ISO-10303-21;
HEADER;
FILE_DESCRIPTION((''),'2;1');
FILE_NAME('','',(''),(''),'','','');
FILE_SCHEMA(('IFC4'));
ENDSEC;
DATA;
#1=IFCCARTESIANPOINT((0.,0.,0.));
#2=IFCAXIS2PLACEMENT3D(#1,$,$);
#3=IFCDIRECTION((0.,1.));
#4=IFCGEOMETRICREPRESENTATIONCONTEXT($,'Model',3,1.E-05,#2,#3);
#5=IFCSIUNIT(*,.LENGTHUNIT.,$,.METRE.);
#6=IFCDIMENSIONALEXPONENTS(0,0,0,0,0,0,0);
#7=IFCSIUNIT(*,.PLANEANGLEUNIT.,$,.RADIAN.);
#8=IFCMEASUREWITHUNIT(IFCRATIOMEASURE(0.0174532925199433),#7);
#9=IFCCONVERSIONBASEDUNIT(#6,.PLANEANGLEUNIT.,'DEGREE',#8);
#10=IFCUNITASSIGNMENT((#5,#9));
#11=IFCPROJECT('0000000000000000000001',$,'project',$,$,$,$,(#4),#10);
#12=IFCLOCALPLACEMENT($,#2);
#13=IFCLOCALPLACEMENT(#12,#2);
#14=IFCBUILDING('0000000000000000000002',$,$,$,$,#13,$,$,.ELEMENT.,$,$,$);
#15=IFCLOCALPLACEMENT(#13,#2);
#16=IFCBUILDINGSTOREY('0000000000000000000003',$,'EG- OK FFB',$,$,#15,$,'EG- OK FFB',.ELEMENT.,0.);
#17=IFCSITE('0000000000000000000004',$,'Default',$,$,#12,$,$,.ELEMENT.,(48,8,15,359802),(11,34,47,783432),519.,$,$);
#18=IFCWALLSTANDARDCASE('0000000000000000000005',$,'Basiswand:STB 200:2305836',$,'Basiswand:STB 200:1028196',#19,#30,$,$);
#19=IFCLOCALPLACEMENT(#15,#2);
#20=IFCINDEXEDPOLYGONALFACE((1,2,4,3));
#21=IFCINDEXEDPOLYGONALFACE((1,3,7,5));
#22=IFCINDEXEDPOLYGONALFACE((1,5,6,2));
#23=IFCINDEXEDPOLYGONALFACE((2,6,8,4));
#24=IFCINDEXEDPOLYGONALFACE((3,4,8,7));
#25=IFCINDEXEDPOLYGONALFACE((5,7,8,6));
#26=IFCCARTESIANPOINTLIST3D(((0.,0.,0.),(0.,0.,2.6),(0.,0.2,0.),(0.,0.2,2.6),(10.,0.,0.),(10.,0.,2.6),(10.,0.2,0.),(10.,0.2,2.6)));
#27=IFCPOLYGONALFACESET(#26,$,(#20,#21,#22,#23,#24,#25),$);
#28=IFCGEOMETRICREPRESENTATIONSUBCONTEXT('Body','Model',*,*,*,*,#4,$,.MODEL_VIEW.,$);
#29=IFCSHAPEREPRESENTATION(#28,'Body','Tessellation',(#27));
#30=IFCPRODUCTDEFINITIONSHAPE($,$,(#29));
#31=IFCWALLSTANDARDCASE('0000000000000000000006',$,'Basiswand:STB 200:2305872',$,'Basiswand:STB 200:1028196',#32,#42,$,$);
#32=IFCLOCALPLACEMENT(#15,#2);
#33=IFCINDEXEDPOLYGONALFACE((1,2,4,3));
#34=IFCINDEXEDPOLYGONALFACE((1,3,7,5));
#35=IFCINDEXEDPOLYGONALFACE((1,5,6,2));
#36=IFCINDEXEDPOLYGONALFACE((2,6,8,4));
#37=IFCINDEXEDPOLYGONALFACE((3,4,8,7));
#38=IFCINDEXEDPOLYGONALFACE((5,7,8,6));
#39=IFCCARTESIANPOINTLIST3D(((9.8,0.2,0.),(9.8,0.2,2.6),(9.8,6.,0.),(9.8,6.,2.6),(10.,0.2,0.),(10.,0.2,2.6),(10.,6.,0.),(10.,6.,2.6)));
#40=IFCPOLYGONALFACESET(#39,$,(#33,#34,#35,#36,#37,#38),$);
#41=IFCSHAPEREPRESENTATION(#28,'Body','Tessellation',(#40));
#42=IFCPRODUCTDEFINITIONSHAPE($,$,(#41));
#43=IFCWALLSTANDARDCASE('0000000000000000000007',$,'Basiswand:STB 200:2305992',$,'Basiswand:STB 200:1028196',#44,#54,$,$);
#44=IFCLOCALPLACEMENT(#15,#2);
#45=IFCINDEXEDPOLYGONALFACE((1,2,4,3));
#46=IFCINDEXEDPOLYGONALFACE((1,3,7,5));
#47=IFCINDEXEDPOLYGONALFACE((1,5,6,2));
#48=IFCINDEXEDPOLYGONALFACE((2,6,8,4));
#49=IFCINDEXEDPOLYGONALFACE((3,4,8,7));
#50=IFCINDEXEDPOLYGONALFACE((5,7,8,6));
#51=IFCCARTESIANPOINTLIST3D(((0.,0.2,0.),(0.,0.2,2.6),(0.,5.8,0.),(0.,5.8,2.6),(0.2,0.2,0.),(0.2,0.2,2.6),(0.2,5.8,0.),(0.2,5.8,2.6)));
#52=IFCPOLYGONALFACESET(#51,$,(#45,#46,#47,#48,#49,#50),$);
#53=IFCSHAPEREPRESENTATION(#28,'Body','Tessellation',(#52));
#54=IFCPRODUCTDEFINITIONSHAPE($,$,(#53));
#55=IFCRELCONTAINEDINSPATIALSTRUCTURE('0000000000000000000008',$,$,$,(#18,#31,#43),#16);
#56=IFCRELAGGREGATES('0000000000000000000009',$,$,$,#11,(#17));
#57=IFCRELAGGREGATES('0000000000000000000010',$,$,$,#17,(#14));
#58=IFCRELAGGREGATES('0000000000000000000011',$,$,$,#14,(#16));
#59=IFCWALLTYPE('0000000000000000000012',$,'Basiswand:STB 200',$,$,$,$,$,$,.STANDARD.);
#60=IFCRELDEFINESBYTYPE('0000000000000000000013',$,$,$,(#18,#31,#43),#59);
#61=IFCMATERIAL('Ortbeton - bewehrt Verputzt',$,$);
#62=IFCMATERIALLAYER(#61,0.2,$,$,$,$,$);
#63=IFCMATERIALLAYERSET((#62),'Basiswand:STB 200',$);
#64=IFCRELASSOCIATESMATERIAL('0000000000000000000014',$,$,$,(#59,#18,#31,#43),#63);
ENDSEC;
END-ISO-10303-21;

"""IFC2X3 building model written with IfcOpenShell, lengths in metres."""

from ifc_helpers import new_model, entity, si_unit, converted_unit, direction, frame, frame_2d, origin, place, context, subcontext, project, spatial, rectangle, extrude, material, layer, layer_set, layer_usage, type_object, element, save


model = new_model("IFC2X3")

# Units and contexts
model_context = context("Model", 3, precision=1e-05, world=origin(), true_north=direction((0.0, 1.0)))
body_context = subcontext(model_context, "Body", "Model", "MODEL_VIEW")
ifc_project = project(units=[si_unit("LENGTHUNIT", "METRE"), converted_unit("PLANEANGLEUNIT", "DEGREE", entity("IfcRatioMeasure", 0.0174532925199433), si_unit("PLANEANGLEUNIT", "RADIAN"), dimensions=[0, 0, 0, 0, 0, 0, 0])], contexts=[model_context])

# Site, building, storey
site_placement = place(None, frame((0.0, 0.0, 0.0)))
site = spatial("IfcSite", under=ifc_project, at=site_placement, Name="Default", CompositionType="ELEMENT", RefLatitude=(48, 8, 15, 359802), RefLongitude=(11, 34, 47, 783432), RefElevation=519.0)
building_placement = place(site_placement, origin())
building = spatial("IfcBuilding", under=site, at=building_placement, CompositionType="ELEMENT")
storey_placement = place(building_placement, origin())
storey = spatial("IfcBuildingStorey", under=building, at=storey_placement, Name="EG- OK FFB", LongName="EG- OK FFB", CompositionType="ELEMENT", Elevation=0.0)

# Walls
ifc_material = material(Name="Ortbeton - bewehrt Verputzt")
ifc_layer = layer(ifc_material, 0.2)
ifc_layer_set = layer_set([ifc_layer], Name="Basiswand:STB 200")
ifc_layer_usage_1 = layer_usage(ifc_layer_set, "AXIS2", "NEGATIVE", 0.1)
wall_type = type_object("IfcWallType", Name="Basiswand:STB 200", PredefinedType="STANDARD", material=ifc_layer_set)
wall_1_placement = place(storey_placement, frame((0.0, 0.1, 0.0)))
element("IfcWallStandardCase", 1, at=wall_1_placement, inside=storey, type_object=wall_type, material=ifc_layer_usage_1, Name="Basiswand:STB 200:2305836", ObjectType="Basiswand:STB 200:1028196", context=body_context, shape_type="SweptSolid", body=[
    extrude(rectangle(XDim=10.0, YDim=0.2, at=frame_2d((5.0, 0.0), x_axis=(-1.0, 0.0))), origin(), (0.0, 0.0, 1.0), 2.6),
])
ifc_layer_usage_2 = layer_usage(ifc_layer_set, "AXIS2", "NEGATIVE", 0.1)
wall_2_placement = place(storey_placement, frame((9.9, 0.2, 0.0), z_axis=(0.0, 0.0, 1.0), x_axis=(0.0, 1.0, 0.0)))
element("IfcWallStandardCase", 2, at=wall_2_placement, inside=storey, type_object=wall_type, material=ifc_layer_usage_2, Name="Basiswand:STB 200:2305872", ObjectType="Basiswand:STB 200:1028196", context=body_context, shape_type="SweptSolid", body=[
    extrude(rectangle(XDim=5.8, YDim=0.2, at=frame_2d((2.9, 0.0), x_axis=(-1.0, 0.0))), origin(), (0.0, 0.0, 1.0), 2.6),
])
ifc_layer_usage_3 = layer_usage(ifc_layer_set, "AXIS2", "NEGATIVE", 0.1)
wall_3_placement = place(storey_placement, frame((0.1, 5.8, 0.0), z_axis=(0.0, 0.0, 1.0), x_axis=(0.0, -1.0, 0.0)))
element("IfcWallStandardCase", 3, at=wall_3_placement, inside=storey, type_object=wall_type, material=ifc_layer_usage_3, Name="Basiswand:STB 200:2305992", ObjectType="Basiswand:STB 200:1028196", context=body_context, shape_type="SweptSolid", body=[
    extrude(rectangle(XDim=5.6, YDim=0.2, at=frame_2d((2.8, 0.0), x_axis=(-1.0, 0.0))), origin(), (0.0, 0.0, 1.0), 2.6),
])

save(model, "model.ifc")
